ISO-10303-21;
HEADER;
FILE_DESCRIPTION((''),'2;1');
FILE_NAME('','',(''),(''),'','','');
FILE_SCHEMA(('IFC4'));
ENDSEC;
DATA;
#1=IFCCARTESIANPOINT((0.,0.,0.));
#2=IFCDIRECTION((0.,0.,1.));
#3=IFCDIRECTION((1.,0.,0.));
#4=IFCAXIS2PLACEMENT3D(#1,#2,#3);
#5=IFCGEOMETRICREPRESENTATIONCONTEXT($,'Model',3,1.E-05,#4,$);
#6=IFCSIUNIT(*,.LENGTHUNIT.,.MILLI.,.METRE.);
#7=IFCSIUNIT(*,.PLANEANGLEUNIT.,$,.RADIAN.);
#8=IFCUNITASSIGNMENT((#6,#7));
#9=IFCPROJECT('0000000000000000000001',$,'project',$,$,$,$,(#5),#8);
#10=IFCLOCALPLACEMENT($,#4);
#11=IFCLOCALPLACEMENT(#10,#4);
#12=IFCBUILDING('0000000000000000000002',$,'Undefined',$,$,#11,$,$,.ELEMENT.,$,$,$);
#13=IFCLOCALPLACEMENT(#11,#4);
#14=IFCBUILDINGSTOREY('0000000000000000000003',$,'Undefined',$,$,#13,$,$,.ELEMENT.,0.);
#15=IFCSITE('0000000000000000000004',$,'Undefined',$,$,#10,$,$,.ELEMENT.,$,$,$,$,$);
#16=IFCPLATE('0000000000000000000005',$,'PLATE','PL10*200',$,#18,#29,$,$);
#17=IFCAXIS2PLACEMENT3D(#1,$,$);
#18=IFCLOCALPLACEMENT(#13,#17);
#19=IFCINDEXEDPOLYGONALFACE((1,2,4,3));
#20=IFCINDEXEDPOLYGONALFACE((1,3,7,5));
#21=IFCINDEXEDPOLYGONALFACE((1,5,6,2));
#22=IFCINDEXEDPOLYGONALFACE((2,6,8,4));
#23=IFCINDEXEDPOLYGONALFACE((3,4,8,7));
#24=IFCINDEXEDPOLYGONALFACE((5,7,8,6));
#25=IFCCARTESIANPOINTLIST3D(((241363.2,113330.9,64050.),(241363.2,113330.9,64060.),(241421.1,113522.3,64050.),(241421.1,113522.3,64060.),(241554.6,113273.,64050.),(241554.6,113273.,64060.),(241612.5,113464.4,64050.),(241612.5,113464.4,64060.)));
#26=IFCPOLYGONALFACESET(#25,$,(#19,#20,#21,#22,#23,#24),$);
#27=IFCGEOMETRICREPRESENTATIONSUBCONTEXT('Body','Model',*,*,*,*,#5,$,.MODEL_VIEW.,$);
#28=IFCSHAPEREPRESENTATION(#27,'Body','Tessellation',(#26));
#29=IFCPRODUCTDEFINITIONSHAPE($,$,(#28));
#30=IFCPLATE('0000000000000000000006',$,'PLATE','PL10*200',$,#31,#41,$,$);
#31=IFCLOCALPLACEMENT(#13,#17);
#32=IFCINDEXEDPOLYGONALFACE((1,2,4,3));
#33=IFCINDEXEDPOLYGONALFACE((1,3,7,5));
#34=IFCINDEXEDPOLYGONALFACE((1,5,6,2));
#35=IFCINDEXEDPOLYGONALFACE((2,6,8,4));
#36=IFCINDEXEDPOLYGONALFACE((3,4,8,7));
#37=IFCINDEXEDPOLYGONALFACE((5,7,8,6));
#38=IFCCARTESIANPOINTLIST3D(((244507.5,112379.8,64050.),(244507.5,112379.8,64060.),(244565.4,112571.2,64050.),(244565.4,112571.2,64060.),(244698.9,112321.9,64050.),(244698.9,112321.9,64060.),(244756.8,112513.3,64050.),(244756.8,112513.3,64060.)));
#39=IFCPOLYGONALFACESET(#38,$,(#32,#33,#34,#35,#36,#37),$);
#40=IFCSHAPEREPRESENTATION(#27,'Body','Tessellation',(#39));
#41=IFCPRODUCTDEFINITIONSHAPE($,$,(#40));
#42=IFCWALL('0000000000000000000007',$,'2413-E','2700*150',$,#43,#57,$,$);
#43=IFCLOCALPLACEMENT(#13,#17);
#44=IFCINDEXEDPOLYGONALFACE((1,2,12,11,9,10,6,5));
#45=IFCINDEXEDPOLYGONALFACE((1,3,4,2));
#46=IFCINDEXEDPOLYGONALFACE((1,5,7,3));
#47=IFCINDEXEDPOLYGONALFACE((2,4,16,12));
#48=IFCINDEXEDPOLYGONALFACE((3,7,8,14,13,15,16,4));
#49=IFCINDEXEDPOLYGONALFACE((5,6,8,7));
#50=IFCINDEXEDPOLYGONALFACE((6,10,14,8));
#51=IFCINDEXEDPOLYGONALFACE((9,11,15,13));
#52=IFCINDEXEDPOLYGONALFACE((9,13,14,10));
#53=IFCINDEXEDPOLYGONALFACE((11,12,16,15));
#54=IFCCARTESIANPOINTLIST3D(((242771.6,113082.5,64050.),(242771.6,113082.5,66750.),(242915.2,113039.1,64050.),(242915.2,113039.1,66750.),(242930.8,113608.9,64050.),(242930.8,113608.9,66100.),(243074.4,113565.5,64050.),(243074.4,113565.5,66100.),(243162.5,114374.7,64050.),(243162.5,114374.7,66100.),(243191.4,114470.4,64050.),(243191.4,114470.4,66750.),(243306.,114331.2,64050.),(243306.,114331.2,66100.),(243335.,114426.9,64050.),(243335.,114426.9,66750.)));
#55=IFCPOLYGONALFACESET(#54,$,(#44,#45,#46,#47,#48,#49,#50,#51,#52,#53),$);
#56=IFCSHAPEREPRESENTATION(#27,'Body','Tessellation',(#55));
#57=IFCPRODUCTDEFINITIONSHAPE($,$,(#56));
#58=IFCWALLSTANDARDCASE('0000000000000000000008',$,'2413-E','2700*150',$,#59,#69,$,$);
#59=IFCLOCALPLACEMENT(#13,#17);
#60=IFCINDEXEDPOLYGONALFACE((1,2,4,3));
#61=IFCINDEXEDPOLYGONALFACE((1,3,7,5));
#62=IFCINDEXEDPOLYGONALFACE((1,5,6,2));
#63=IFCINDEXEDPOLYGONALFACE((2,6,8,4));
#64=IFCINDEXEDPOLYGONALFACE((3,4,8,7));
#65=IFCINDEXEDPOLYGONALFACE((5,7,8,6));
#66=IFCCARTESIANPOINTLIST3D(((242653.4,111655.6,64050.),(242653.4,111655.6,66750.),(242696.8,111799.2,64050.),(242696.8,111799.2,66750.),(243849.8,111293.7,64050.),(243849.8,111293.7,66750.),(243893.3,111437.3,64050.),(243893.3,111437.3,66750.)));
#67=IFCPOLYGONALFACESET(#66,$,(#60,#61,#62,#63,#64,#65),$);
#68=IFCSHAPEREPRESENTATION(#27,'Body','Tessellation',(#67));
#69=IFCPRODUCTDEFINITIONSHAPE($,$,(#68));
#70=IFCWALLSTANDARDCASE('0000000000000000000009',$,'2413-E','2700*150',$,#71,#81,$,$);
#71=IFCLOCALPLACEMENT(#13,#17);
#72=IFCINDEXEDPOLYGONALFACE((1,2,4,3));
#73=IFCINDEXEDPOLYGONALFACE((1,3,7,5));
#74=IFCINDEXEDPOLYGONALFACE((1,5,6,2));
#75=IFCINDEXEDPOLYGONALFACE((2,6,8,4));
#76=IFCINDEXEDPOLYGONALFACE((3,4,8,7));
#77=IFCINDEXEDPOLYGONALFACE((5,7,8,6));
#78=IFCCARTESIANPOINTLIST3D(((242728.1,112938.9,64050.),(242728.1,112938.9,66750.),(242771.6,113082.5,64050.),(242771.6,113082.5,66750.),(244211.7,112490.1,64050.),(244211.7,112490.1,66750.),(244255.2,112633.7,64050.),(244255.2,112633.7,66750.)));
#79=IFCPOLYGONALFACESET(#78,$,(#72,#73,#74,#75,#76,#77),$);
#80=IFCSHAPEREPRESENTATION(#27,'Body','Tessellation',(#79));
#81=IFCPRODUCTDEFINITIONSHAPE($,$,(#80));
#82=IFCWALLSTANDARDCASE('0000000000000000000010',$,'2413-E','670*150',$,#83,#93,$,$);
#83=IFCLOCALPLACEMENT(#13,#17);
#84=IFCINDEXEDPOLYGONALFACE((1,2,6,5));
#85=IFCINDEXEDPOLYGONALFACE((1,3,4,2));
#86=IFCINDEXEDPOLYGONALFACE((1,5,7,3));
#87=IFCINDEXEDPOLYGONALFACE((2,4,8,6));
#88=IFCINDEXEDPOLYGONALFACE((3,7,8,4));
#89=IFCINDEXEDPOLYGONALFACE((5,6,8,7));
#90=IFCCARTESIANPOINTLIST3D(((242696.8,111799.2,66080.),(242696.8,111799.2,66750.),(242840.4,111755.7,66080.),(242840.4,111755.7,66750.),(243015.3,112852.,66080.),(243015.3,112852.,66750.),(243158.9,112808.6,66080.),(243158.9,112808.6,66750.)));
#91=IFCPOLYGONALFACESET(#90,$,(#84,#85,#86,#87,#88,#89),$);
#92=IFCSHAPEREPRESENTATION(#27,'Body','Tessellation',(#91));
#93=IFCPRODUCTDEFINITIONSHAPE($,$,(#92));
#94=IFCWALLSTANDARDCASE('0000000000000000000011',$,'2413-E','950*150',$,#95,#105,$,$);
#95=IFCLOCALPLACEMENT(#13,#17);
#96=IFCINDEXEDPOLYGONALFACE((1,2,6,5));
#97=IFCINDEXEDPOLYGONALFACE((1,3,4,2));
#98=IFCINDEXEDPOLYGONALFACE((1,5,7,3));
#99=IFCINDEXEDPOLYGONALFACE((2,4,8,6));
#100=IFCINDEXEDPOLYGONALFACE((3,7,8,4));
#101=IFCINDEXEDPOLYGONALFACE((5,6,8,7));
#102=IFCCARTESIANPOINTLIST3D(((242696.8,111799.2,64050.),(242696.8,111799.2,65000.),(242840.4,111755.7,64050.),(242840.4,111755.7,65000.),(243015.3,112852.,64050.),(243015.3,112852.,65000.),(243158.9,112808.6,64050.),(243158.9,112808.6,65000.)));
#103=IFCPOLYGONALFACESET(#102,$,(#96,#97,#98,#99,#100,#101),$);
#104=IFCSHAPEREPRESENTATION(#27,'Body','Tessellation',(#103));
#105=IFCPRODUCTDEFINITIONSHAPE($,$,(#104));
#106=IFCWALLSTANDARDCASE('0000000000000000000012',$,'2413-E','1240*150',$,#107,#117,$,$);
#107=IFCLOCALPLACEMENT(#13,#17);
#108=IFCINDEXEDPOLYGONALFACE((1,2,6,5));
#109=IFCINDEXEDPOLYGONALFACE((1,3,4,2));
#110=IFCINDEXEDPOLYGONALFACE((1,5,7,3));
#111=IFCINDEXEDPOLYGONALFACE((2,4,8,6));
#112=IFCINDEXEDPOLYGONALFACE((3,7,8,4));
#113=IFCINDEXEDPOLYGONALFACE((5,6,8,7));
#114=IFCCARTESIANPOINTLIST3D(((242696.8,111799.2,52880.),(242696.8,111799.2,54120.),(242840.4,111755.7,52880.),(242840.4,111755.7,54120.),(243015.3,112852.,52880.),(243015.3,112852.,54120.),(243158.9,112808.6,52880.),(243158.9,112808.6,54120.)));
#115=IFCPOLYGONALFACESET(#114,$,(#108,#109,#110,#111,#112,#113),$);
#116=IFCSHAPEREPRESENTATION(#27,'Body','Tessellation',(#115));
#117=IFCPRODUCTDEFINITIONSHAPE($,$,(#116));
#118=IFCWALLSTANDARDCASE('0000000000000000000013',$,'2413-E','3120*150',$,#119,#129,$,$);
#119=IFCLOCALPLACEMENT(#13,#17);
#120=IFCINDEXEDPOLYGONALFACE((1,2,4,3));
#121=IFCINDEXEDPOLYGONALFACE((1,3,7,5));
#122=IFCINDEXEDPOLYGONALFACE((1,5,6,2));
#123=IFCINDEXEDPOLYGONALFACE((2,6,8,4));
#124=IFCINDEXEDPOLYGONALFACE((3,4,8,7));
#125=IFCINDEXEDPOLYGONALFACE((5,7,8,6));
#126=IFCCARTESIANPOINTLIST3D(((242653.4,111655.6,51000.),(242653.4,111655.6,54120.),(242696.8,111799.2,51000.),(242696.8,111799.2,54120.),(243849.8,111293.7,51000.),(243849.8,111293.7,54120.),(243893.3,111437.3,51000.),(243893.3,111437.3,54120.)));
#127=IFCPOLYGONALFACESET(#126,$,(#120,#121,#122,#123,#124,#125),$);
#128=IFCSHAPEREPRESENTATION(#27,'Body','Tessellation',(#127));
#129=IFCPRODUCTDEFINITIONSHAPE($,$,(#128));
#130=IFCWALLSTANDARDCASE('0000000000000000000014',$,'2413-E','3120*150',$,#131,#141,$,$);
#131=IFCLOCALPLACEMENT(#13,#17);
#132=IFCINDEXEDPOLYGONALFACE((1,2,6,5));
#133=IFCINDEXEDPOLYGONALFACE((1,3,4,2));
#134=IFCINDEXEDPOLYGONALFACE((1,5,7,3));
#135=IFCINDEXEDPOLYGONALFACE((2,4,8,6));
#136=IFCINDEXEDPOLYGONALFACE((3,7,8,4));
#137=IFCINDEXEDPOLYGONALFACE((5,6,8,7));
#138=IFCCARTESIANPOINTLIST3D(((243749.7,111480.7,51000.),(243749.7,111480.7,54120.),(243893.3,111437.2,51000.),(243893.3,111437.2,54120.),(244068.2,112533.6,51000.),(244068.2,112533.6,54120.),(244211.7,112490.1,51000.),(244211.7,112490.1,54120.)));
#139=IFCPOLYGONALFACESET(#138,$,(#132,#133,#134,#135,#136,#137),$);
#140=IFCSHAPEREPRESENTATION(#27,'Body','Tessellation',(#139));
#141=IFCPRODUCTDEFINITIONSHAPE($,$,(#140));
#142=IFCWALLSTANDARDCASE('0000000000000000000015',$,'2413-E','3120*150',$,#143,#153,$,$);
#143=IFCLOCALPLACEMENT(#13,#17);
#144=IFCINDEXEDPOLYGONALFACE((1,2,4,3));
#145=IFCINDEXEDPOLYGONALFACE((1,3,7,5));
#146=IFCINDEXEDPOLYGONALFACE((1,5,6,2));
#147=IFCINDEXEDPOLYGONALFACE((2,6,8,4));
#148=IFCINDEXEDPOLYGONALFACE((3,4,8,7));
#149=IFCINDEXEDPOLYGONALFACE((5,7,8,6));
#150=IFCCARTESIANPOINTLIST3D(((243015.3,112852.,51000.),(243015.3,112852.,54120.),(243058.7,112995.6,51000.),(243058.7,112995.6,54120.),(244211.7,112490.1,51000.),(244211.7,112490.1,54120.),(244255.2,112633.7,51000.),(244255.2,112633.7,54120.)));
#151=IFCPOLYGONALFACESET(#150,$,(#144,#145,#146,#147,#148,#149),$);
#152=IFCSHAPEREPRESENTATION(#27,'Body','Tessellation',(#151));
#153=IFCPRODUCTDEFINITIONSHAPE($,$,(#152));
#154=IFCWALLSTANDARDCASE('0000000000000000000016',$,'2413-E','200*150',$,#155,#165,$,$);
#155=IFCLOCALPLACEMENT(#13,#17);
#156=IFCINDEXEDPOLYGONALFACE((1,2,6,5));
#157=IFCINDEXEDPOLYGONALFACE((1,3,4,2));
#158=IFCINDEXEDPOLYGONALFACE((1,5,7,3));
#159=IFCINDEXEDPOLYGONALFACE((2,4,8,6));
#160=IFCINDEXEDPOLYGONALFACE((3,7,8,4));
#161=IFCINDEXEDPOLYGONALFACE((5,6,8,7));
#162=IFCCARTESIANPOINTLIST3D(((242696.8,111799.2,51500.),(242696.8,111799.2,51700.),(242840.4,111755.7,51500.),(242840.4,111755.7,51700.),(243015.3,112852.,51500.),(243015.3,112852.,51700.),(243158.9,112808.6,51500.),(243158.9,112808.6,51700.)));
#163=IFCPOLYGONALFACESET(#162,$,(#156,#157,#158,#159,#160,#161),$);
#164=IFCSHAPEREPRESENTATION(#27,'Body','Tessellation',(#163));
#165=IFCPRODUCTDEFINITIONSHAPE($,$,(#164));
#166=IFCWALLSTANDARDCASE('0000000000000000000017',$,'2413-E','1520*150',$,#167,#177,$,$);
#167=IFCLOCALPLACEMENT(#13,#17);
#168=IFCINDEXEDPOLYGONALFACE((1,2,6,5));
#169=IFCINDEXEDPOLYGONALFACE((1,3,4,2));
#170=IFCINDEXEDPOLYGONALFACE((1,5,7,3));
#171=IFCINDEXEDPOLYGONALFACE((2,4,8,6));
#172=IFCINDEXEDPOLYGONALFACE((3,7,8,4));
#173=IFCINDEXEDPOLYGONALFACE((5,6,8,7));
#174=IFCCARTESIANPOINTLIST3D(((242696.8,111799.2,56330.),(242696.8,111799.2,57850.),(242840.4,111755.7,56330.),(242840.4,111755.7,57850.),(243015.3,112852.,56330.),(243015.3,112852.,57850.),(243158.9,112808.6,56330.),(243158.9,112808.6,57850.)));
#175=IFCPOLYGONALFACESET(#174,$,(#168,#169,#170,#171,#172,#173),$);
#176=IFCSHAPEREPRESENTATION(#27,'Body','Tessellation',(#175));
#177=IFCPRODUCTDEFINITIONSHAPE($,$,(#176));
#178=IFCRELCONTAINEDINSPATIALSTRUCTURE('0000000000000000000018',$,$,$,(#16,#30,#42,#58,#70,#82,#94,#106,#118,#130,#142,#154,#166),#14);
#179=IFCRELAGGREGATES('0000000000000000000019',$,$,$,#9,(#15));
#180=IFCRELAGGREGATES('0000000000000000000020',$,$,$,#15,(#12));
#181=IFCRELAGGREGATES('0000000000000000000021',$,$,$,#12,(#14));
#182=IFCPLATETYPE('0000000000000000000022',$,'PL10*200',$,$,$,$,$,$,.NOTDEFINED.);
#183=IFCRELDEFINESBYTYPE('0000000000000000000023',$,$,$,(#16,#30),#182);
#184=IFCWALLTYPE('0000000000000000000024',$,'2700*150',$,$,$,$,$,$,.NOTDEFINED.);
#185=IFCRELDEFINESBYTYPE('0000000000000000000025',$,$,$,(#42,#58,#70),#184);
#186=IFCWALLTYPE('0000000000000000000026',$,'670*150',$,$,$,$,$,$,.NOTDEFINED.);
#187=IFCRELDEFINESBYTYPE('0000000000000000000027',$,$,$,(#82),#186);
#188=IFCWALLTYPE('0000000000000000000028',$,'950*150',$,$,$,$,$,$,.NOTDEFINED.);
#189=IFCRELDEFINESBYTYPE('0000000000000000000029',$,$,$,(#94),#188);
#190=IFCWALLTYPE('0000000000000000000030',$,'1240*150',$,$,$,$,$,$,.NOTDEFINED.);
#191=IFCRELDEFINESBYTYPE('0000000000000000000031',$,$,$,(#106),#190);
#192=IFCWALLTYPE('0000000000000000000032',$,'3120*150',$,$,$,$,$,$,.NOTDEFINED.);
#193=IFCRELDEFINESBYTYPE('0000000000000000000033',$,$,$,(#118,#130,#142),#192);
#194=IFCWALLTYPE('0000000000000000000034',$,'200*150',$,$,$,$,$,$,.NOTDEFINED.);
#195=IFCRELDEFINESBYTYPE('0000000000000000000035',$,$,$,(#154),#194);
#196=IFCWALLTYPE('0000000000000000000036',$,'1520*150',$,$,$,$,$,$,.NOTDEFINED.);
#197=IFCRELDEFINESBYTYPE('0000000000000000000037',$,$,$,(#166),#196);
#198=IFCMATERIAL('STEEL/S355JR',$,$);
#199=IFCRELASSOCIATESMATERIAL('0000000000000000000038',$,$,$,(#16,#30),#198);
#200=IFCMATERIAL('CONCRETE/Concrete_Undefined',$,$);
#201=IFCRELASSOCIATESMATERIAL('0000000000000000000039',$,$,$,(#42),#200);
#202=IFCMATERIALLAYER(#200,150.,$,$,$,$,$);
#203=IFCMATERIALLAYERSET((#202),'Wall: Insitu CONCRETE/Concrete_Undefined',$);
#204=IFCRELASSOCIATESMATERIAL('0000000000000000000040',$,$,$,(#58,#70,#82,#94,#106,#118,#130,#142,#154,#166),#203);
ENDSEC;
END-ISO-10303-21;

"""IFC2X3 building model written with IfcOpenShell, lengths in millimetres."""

from ifc_helpers import new_model, si_unit, frame, frame_2d, origin_with_axes, place, context, subcontext, project, spatial, polyline, rectangle, outline, extrude, boolean, material, layer, layer_set, layer_usage, type_object, element, save


model = new_model("IFC2X3")

# Units and contexts
model_context = context("Model", 3, precision=1e-05, world=origin_with_axes())
body_context = subcontext(model_context, "Body", "Model", "MODEL_VIEW")
ifc_project = project(units=[si_unit("LENGTHUNIT", "METRE", prefix="MILLI"), si_unit("PLANEANGLEUNIT", "RADIAN")], contexts=[model_context])

# Site, building, storey
site_placement = place(None, origin_with_axes())
site = spatial("IfcSite", under=ifc_project, at=site_placement, Name="Undefined", CompositionType="ELEMENT")
building_placement = place(site_placement, origin_with_axes())
building = spatial("IfcBuilding", under=site, at=building_placement, Name="Undefined", CompositionType="ELEMENT")
storey_placement = place(building_placement, origin_with_axes())
storey = spatial("IfcBuildingStorey", under=building, at=storey_placement, Name="Undefined", CompositionType="ELEMENT", Elevation=0.0)

# Plates
ifc_material_1 = material(Name="STEEL/S355JR")
plate_type = type_object("IfcPlateType", Name="PL10*200", PredefinedType="NOTDEFINED")
for number, where, z_axis, x_axis, name in (
    (1, (241583.6, 113368.7, 64055.0), (0.0, 0.0, 1.0), (-0.957167, 0.289538, 0.0), "PLATE"),
    (2, (244727.9, 112417.6, 64055.0), (0.0, 0.0, 1.0), (-0.957167, 0.289538, 0.0), "PLATE"),
):
    element("IfcPlate", number, at=place(storey_placement, frame(where, z_axis=z_axis, x_axis=x_axis)), inside=storey, type_object=plate_type, material=ifc_material_1, Name=name, Description="PL10*200", context=body_context, shape_type="SweptSolid", body=[
        extrude(outline(polyline([(200.0, 100.0), (200.0, -100.0), (0.0, -100.0), (0.0, 100.0), (200.0, 100.0)])), frame((0.0, 0.0, -5.0), z_axis=(0.0, 0.0, 1.0), x_axis=(1.0, 0.0, 0.0)), (0.0, 0.0, 1.0), 10.0),
    ])

# Walls
ifc_material_2 = material(Name="CONCRETE/Concrete_Undefined")
wall_type_1 = type_object("IfcWallType", Name="2700*150", PredefinedType="NOTDEFINED")
wall_1_placement = place(storey_placement, frame((242843.4, 113060.8, 64050.0), z_axis=(0.0, 0.0, 1.0), x_axis=(0.289535, 0.957168, 0.0)))
element("IfcWall", 3, at=wall_1_placement, inside=storey, type_object=wall_type_1, material=ifc_material_2, Name="2413-E", Description="2700*150", context=body_context, shape_type="CSG", body=[
    boolean("DIFFERENCE", extrude(rectangle(XDim=1450.0, YDim=150.0, at=frame_2d((0.0, 725.0), x_axis=(0.0, -1.0))), frame((0.0, 0.0, 0.0), z_axis=(0.0, 0.0, 1.0), x_axis=(0.0, -1.0, 0.0)), (0.0, 0.0, 1.0), 2700.0), extrude(rectangle(XDim=800.0, YDim=150.0, at=frame_2d((0.0, 400.0), x_axis=(0.0, -1.0))), frame((1350.0, 0.0, 0.0), z_axis=(0.0, 0.0, 1.0), x_axis=(0.000006, 1.0, 0.0)), (0.0, 0.0, 1.0), 2050.0)),
])
ifc_layer_1 = layer(ifc_material_2, 150.0)
ifc_layer_set_1 = layer_set([ifc_layer_1], Name="Wall: Insitu CONCRETE/Concrete_Undefined")
ifc_layer_usage_1 = layer_usage(ifc_layer_set_1, "AXIS2", "POSITIVE", -75.0)
wall_2_placement = place(storey_placement, frame((242675.1, 111727.4, 64050.0), z_axis=(0.0, 0.0, 1.0), x_axis=(0.957168, -0.289532, 0.0)))
element("IfcWallStandardCase", 4, at=wall_2_placement, inside=storey, type_object=wall_type_1, material=ifc_layer_usage_1, Name="2413-E", Description="2700*150", context=body_context, shape_type="SweptSolid", body=[
    extrude(rectangle(XDim=1250.0, YDim=150.0, at=frame_2d((0.0, 625.0), x_axis=(0.0, -1.0))), frame((0.0, 0.0, 0.0), z_axis=(0.0, 0.0, 1.0), x_axis=(0.0, -1.0, 0.0)), (0.0, 0.0, 1.0), 2700.0),
])
ifc_layer_usage_2 = layer_usage(ifc_layer_set_1, "AXIS2", "POSITIVE", -75.0)
wall_3_placement = place(storey_placement, frame((242749.9, 113010.7, 64050.0), z_axis=(0.0, 0.0, 1.0), x_axis=(0.957168, -0.289533, 0.0)))
element("IfcWallStandardCase", 5, at=wall_3_placement, inside=storey, type_object=wall_type_1, material=ifc_layer_usage_2, Name="2413-E", Description="2700*150", context=body_context, shape_type="SweptSolid", body=[
    extrude(rectangle(XDim=1550.0, YDim=150.0, at=frame_2d((0.0, 775.0), x_axis=(0.0, -1.0))), frame((0.0, 0.0, 0.0), z_axis=(0.0, 0.0, 1.0), x_axis=(0.0, -1.0, 0.0)), (0.0, 0.0, 1.0), 2700.0),
])
ifc_layer_usage_3 = layer_usage(ifc_layer_set_1, "AXIS2", "POSITIVE", -75.0)
wall_type_2 = type_object("IfcWallType", Name="670*150", PredefinedType="NOTDEFINED")
wall_4_placement = place(storey_placement, frame((242768.6, 111777.4, 66080.0), z_axis=(0.0, 0.0, 1.0), x_axis=(0.289534, 0.957168, 0.0)))
element("IfcWallStandardCase", 6, at=wall_4_placement, inside=storey, type_object=wall_type_2, material=ifc_layer_usage_3, Name="2413-E", Description="670*150", context=body_context, shape_type="SweptSolid", body=[
    extrude(rectangle(XDim=1100.0, YDim=150.0, at=frame_2d((0.0, 550.0), x_axis=(0.0, -1.0))), frame((0.0, 0.0, 0.0), z_axis=(0.0, 0.0, 1.0), x_axis=(0.0, -1.0, 0.0)), (0.0, 0.0, 1.0), 670.0),
])
ifc_layer_usage_4 = layer_usage(ifc_layer_set_1, "AXIS2", "POSITIVE", -75.0)
wall_type_3 = type_object("IfcWallType", Name="950*150", PredefinedType="NOTDEFINED")
wall_5_placement = place(storey_placement, frame((242768.6, 111777.4, 64050.0), z_axis=(0.0, 0.0, 1.0), x_axis=(0.289534, 0.957168, 0.0)))
element("IfcWallStandardCase", 7, at=wall_5_placement, inside=storey, type_object=wall_type_3, material=ifc_layer_usage_4, Name="2413-E", Description="950*150", context=body_context, shape_type="SweptSolid", body=[
    extrude(rectangle(XDim=1100.0, YDim=150.0, at=frame_2d((0.0, 550.0), x_axis=(0.0, -1.0))), frame((0.0, 0.0, 0.0), z_axis=(0.0, 0.0, 1.0), x_axis=(0.0, -1.0, 0.0)), (0.0, 0.0, 1.0), 950.0),
])
ifc_layer_usage_5 = layer_usage(ifc_layer_set_1, "AXIS2", "POSITIVE", -75.0)
wall_type_4 = type_object("IfcWallType", Name="1240*150", PredefinedType="NOTDEFINED")
wall_6_placement = place(storey_placement, frame((242768.6, 111777.4, 52880.0), z_axis=(0.0, 0.0, 1.0), x_axis=(0.289534, 0.957168, 0.0)))
element("IfcWallStandardCase", 8, at=wall_6_placement, inside=storey, type_object=wall_type_4, material=ifc_layer_usage_5, Name="2413-E", Description="1240*150", context=body_context, shape_type="SweptSolid", body=[
    extrude(rectangle(XDim=1100.0, YDim=150.0, at=frame_2d((0.0, 550.0), x_axis=(0.0, -1.0))), frame((0.0, 0.0, 0.0), z_axis=(0.0, 0.0, 1.0), x_axis=(0.0, -1.0, 0.0)), (0.0, 0.0, 1.0), 1240.0),
])
ifc_layer_usage_6 = layer_usage(ifc_layer_set_1, "AXIS2", "POSITIVE", -75.0)
wall_type_5 = type_object("IfcWallType", Name="3120*150", PredefinedType="NOTDEFINED")
wall_7_placement = place(storey_placement, frame((242675.1, 111727.4, 51000.0), z_axis=(0.0, 0.0, 1.0), x_axis=(0.957168, -0.289532, 0.0)))
element("IfcWallStandardCase", 9, at=wall_7_placement, inside=storey, type_object=wall_type_5, material=ifc_layer_usage_6, Name="2413-E", Description="3120*150", context=body_context, shape_type="SweptSolid", body=[
    extrude(rectangle(XDim=1250.0, YDim=150.0, at=frame_2d((0.0, 625.0), x_axis=(0.0, -1.0))), frame((0.0, 0.0, 0.0), z_axis=(0.0, 0.0, 1.0), x_axis=(0.0, -1.0, 0.0)), (0.0, 0.0, 1.0), 3120.0),
])
ifc_layer_usage_7 = layer_usage(ifc_layer_set_1, "AXIS2", "POSITIVE", -75.0)
wall_8_placement = place(storey_placement, frame((244140.0, 112511.8, 51000.0), z_axis=(0.0, 0.0, 1.0), x_axis=(-0.289534, -0.957168, 0.0)))
element("IfcWallStandardCase", 10, at=wall_8_placement, inside=storey, type_object=wall_type_5, material=ifc_layer_usage_7, Name="2413-E", Description="3120*150", context=body_context, shape_type="SweptSolid", body=[
    extrude(rectangle(XDim=1100.0, YDim=150.0, at=frame_2d((0.0, 550.0), x_axis=(0.0, -1.0))), frame((0.0, 0.0, 0.0), z_axis=(0.0, 0.0, 1.0), x_axis=(0.0, -1.0, 0.0)), (0.0, 0.0, 1.0), 3120.0),
])
ifc_layer_usage_8 = layer_usage(ifc_layer_set_1, "AXIS2", "POSITIVE", -75.0)
wall_9_placement = place(storey_placement, frame((243037.0, 112923.8, 51000.0), z_axis=(0.0, 0.0, 1.0), x_axis=(0.957168, -0.289532, 0.0)))
element("IfcWallStandardCase", 11, at=wall_9_placement, inside=storey, type_object=wall_type_5, material=ifc_layer_usage_8, Name="2413-E", Description="3120*150", context=body_context, shape_type="SweptSolid", body=[
    extrude(rectangle(XDim=1250.0, YDim=150.0, at=frame_2d((0.0, 625.0), x_axis=(0.0, -1.0))), frame((0.0, 0.0, 0.0), z_axis=(0.0, 0.0, 1.0), x_axis=(0.0, -1.0, 0.0)), (0.0, 0.0, 1.0), 3120.0),
])
ifc_layer_usage_9 = layer_usage(ifc_layer_set_1, "AXIS2", "POSITIVE", -75.0)
wall_type_6 = type_object("IfcWallType", Name="200*150", PredefinedType="NOTDEFINED")
wall_10_placement = place(storey_placement, frame((242768.6, 111777.4, 51500.0), z_axis=(0.0, 0.0, 1.0), x_axis=(0.289534, 0.957168, 0.0)))
element("IfcWallStandardCase", 12, at=wall_10_placement, inside=storey, type_object=wall_type_6, material=ifc_layer_usage_9, Name="2413-E", Description="200*150", context=body_context, shape_type="SweptSolid", body=[
    extrude(rectangle(XDim=1100.0, YDim=150.0, at=frame_2d((0.0, 550.0), x_axis=(0.0, -1.0))), frame((0.0, 0.0, 0.0), z_axis=(0.0, 0.0, 1.0), x_axis=(0.0, -1.0, 0.0)), (0.0, 0.0, 1.0), 200.0),
])
ifc_layer_usage_10 = layer_usage(ifc_layer_set_1, "AXIS2", "POSITIVE", -75.0)
wall_type_7 = type_object("IfcWallType", Name="1520*150", PredefinedType="NOTDEFINED")
wall_11_placement = place(storey_placement, frame((242768.6, 111777.4, 56330.0), z_axis=(0.0, 0.0, 1.0), x_axis=(0.289534, 0.957168, 0.0)))
element("IfcWallStandardCase", 13, at=wall_11_placement, inside=storey, type_object=wall_type_7, material=ifc_layer_usage_10, Name="2413-E", Description="1520*150", context=body_context, shape_type="SweptSolid", body=[
    extrude(rectangle(XDim=1100.0, YDim=150.0, at=frame_2d((0.0, 550.0), x_axis=(0.0, -1.0))), frame((0.0, 0.0, 0.0), z_axis=(0.0, 0.0, 1.0), x_axis=(0.0, -1.0, 0.0)), (0.0, 0.0, 1.0), 1520.0),
])

save(model, "model.ifc")
